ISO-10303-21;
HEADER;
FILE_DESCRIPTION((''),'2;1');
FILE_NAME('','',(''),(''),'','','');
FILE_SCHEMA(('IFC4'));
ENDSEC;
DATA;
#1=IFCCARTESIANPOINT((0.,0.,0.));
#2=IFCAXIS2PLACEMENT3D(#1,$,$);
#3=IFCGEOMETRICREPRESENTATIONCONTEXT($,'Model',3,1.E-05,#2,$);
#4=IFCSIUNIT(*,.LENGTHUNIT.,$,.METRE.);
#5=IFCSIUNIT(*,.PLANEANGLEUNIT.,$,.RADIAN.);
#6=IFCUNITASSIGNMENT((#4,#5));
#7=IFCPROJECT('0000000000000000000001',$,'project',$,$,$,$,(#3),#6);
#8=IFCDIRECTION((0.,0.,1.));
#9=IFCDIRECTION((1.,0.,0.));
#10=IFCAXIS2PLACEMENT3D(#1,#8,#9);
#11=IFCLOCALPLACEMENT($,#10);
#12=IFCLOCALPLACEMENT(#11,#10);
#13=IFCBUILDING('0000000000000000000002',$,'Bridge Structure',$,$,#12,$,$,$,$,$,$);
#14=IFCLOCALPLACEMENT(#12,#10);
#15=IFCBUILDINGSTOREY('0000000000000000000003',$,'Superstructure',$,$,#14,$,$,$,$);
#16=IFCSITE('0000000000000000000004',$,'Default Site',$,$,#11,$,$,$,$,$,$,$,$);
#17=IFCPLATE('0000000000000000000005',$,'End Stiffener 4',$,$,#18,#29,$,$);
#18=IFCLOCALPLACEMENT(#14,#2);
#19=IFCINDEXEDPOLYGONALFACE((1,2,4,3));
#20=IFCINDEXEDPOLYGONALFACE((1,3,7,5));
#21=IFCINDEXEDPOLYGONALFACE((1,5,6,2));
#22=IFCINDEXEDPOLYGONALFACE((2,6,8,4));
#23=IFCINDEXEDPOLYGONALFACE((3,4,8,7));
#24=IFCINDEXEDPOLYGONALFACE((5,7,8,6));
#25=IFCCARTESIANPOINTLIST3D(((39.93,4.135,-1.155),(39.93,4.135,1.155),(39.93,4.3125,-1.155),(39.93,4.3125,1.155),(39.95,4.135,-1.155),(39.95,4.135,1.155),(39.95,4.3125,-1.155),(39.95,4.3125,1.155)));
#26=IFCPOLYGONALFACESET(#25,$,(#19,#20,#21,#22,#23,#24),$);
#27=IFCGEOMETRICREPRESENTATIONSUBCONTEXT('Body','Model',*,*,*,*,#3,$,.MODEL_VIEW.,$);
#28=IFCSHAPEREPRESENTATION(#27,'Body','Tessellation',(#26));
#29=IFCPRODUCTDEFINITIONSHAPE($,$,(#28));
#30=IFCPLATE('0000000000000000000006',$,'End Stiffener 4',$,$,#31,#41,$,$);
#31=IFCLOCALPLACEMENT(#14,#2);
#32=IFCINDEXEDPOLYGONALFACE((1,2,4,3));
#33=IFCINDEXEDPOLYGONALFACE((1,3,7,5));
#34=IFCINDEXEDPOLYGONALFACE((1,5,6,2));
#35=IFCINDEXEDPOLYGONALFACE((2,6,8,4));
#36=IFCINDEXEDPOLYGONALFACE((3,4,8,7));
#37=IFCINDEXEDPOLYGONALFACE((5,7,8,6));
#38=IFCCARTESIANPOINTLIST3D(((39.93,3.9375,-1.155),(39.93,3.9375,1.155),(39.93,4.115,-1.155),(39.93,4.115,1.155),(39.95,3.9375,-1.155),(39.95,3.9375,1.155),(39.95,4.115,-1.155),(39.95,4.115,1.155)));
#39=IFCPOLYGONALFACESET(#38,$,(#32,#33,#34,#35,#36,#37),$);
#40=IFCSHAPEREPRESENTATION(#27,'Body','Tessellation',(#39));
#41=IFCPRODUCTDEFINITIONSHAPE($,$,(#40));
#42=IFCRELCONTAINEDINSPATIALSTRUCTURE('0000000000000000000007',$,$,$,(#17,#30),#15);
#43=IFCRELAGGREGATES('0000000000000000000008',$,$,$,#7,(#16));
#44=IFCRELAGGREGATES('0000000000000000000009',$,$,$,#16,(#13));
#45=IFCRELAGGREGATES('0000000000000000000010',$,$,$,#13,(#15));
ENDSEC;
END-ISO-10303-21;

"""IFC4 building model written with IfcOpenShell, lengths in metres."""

from ifc_helpers import new_model, si_unit, frame, origin, origin_with_axes, origin_2d_with_axis, place, context, subcontext, project, spatial, rectangle, extrude, element, save


model = new_model("IFC4")

# Units and contexts
model_context = context("Model", 3, precision=1e-05, world=origin())
body_context = subcontext(model_context, "Body", "Model", "MODEL_VIEW")
ifc_project = project(units=[si_unit("LENGTHUNIT", "METRE"), si_unit("PLANEANGLEUNIT", "RADIAN")], contexts=[model_context])

# Site, building, storey
site_placement = place(None, origin_with_axes())
site = spatial("IfcSite", under=ifc_project, at=site_placement, Name="Default Site")
building_placement = place(site_placement, origin_with_axes())
building = spatial("IfcBuilding", under=site, at=building_placement, Name="Bridge Structure")
storey_placement = place(building_placement, origin_with_axes())
storey = spatial("IfcBuildingStorey", under=building, at=storey_placement, Name="Superstructure")

# Plates
for number, where, z_axis, x_axis, name in (
    (1, (39.94, 4.2237, -1.155), (0.0, 0.0, 1.0), (1.0, 0.0, 0.0), "End Stiffener 4"),
    (2, (39.94, 4.0263, -1.155), (0.0, 0.0, 1.0), (1.0, 0.0, 0.0), "End Stiffener 4"),
):
    element("IfcPlate", number, at=place(storey_placement, frame(where, z_axis=z_axis, x_axis=x_axis)), inside=storey, Name=name, context=body_context, shape_type="SweptSolid", body=[
        extrude(rectangle(XDim=0.02, YDim=0.1775, at=origin_2d_with_axis()), origin_with_axes(), (0.0, 0.0, 1.0), 2.31),
    ])

save(model, "model.ifc")
